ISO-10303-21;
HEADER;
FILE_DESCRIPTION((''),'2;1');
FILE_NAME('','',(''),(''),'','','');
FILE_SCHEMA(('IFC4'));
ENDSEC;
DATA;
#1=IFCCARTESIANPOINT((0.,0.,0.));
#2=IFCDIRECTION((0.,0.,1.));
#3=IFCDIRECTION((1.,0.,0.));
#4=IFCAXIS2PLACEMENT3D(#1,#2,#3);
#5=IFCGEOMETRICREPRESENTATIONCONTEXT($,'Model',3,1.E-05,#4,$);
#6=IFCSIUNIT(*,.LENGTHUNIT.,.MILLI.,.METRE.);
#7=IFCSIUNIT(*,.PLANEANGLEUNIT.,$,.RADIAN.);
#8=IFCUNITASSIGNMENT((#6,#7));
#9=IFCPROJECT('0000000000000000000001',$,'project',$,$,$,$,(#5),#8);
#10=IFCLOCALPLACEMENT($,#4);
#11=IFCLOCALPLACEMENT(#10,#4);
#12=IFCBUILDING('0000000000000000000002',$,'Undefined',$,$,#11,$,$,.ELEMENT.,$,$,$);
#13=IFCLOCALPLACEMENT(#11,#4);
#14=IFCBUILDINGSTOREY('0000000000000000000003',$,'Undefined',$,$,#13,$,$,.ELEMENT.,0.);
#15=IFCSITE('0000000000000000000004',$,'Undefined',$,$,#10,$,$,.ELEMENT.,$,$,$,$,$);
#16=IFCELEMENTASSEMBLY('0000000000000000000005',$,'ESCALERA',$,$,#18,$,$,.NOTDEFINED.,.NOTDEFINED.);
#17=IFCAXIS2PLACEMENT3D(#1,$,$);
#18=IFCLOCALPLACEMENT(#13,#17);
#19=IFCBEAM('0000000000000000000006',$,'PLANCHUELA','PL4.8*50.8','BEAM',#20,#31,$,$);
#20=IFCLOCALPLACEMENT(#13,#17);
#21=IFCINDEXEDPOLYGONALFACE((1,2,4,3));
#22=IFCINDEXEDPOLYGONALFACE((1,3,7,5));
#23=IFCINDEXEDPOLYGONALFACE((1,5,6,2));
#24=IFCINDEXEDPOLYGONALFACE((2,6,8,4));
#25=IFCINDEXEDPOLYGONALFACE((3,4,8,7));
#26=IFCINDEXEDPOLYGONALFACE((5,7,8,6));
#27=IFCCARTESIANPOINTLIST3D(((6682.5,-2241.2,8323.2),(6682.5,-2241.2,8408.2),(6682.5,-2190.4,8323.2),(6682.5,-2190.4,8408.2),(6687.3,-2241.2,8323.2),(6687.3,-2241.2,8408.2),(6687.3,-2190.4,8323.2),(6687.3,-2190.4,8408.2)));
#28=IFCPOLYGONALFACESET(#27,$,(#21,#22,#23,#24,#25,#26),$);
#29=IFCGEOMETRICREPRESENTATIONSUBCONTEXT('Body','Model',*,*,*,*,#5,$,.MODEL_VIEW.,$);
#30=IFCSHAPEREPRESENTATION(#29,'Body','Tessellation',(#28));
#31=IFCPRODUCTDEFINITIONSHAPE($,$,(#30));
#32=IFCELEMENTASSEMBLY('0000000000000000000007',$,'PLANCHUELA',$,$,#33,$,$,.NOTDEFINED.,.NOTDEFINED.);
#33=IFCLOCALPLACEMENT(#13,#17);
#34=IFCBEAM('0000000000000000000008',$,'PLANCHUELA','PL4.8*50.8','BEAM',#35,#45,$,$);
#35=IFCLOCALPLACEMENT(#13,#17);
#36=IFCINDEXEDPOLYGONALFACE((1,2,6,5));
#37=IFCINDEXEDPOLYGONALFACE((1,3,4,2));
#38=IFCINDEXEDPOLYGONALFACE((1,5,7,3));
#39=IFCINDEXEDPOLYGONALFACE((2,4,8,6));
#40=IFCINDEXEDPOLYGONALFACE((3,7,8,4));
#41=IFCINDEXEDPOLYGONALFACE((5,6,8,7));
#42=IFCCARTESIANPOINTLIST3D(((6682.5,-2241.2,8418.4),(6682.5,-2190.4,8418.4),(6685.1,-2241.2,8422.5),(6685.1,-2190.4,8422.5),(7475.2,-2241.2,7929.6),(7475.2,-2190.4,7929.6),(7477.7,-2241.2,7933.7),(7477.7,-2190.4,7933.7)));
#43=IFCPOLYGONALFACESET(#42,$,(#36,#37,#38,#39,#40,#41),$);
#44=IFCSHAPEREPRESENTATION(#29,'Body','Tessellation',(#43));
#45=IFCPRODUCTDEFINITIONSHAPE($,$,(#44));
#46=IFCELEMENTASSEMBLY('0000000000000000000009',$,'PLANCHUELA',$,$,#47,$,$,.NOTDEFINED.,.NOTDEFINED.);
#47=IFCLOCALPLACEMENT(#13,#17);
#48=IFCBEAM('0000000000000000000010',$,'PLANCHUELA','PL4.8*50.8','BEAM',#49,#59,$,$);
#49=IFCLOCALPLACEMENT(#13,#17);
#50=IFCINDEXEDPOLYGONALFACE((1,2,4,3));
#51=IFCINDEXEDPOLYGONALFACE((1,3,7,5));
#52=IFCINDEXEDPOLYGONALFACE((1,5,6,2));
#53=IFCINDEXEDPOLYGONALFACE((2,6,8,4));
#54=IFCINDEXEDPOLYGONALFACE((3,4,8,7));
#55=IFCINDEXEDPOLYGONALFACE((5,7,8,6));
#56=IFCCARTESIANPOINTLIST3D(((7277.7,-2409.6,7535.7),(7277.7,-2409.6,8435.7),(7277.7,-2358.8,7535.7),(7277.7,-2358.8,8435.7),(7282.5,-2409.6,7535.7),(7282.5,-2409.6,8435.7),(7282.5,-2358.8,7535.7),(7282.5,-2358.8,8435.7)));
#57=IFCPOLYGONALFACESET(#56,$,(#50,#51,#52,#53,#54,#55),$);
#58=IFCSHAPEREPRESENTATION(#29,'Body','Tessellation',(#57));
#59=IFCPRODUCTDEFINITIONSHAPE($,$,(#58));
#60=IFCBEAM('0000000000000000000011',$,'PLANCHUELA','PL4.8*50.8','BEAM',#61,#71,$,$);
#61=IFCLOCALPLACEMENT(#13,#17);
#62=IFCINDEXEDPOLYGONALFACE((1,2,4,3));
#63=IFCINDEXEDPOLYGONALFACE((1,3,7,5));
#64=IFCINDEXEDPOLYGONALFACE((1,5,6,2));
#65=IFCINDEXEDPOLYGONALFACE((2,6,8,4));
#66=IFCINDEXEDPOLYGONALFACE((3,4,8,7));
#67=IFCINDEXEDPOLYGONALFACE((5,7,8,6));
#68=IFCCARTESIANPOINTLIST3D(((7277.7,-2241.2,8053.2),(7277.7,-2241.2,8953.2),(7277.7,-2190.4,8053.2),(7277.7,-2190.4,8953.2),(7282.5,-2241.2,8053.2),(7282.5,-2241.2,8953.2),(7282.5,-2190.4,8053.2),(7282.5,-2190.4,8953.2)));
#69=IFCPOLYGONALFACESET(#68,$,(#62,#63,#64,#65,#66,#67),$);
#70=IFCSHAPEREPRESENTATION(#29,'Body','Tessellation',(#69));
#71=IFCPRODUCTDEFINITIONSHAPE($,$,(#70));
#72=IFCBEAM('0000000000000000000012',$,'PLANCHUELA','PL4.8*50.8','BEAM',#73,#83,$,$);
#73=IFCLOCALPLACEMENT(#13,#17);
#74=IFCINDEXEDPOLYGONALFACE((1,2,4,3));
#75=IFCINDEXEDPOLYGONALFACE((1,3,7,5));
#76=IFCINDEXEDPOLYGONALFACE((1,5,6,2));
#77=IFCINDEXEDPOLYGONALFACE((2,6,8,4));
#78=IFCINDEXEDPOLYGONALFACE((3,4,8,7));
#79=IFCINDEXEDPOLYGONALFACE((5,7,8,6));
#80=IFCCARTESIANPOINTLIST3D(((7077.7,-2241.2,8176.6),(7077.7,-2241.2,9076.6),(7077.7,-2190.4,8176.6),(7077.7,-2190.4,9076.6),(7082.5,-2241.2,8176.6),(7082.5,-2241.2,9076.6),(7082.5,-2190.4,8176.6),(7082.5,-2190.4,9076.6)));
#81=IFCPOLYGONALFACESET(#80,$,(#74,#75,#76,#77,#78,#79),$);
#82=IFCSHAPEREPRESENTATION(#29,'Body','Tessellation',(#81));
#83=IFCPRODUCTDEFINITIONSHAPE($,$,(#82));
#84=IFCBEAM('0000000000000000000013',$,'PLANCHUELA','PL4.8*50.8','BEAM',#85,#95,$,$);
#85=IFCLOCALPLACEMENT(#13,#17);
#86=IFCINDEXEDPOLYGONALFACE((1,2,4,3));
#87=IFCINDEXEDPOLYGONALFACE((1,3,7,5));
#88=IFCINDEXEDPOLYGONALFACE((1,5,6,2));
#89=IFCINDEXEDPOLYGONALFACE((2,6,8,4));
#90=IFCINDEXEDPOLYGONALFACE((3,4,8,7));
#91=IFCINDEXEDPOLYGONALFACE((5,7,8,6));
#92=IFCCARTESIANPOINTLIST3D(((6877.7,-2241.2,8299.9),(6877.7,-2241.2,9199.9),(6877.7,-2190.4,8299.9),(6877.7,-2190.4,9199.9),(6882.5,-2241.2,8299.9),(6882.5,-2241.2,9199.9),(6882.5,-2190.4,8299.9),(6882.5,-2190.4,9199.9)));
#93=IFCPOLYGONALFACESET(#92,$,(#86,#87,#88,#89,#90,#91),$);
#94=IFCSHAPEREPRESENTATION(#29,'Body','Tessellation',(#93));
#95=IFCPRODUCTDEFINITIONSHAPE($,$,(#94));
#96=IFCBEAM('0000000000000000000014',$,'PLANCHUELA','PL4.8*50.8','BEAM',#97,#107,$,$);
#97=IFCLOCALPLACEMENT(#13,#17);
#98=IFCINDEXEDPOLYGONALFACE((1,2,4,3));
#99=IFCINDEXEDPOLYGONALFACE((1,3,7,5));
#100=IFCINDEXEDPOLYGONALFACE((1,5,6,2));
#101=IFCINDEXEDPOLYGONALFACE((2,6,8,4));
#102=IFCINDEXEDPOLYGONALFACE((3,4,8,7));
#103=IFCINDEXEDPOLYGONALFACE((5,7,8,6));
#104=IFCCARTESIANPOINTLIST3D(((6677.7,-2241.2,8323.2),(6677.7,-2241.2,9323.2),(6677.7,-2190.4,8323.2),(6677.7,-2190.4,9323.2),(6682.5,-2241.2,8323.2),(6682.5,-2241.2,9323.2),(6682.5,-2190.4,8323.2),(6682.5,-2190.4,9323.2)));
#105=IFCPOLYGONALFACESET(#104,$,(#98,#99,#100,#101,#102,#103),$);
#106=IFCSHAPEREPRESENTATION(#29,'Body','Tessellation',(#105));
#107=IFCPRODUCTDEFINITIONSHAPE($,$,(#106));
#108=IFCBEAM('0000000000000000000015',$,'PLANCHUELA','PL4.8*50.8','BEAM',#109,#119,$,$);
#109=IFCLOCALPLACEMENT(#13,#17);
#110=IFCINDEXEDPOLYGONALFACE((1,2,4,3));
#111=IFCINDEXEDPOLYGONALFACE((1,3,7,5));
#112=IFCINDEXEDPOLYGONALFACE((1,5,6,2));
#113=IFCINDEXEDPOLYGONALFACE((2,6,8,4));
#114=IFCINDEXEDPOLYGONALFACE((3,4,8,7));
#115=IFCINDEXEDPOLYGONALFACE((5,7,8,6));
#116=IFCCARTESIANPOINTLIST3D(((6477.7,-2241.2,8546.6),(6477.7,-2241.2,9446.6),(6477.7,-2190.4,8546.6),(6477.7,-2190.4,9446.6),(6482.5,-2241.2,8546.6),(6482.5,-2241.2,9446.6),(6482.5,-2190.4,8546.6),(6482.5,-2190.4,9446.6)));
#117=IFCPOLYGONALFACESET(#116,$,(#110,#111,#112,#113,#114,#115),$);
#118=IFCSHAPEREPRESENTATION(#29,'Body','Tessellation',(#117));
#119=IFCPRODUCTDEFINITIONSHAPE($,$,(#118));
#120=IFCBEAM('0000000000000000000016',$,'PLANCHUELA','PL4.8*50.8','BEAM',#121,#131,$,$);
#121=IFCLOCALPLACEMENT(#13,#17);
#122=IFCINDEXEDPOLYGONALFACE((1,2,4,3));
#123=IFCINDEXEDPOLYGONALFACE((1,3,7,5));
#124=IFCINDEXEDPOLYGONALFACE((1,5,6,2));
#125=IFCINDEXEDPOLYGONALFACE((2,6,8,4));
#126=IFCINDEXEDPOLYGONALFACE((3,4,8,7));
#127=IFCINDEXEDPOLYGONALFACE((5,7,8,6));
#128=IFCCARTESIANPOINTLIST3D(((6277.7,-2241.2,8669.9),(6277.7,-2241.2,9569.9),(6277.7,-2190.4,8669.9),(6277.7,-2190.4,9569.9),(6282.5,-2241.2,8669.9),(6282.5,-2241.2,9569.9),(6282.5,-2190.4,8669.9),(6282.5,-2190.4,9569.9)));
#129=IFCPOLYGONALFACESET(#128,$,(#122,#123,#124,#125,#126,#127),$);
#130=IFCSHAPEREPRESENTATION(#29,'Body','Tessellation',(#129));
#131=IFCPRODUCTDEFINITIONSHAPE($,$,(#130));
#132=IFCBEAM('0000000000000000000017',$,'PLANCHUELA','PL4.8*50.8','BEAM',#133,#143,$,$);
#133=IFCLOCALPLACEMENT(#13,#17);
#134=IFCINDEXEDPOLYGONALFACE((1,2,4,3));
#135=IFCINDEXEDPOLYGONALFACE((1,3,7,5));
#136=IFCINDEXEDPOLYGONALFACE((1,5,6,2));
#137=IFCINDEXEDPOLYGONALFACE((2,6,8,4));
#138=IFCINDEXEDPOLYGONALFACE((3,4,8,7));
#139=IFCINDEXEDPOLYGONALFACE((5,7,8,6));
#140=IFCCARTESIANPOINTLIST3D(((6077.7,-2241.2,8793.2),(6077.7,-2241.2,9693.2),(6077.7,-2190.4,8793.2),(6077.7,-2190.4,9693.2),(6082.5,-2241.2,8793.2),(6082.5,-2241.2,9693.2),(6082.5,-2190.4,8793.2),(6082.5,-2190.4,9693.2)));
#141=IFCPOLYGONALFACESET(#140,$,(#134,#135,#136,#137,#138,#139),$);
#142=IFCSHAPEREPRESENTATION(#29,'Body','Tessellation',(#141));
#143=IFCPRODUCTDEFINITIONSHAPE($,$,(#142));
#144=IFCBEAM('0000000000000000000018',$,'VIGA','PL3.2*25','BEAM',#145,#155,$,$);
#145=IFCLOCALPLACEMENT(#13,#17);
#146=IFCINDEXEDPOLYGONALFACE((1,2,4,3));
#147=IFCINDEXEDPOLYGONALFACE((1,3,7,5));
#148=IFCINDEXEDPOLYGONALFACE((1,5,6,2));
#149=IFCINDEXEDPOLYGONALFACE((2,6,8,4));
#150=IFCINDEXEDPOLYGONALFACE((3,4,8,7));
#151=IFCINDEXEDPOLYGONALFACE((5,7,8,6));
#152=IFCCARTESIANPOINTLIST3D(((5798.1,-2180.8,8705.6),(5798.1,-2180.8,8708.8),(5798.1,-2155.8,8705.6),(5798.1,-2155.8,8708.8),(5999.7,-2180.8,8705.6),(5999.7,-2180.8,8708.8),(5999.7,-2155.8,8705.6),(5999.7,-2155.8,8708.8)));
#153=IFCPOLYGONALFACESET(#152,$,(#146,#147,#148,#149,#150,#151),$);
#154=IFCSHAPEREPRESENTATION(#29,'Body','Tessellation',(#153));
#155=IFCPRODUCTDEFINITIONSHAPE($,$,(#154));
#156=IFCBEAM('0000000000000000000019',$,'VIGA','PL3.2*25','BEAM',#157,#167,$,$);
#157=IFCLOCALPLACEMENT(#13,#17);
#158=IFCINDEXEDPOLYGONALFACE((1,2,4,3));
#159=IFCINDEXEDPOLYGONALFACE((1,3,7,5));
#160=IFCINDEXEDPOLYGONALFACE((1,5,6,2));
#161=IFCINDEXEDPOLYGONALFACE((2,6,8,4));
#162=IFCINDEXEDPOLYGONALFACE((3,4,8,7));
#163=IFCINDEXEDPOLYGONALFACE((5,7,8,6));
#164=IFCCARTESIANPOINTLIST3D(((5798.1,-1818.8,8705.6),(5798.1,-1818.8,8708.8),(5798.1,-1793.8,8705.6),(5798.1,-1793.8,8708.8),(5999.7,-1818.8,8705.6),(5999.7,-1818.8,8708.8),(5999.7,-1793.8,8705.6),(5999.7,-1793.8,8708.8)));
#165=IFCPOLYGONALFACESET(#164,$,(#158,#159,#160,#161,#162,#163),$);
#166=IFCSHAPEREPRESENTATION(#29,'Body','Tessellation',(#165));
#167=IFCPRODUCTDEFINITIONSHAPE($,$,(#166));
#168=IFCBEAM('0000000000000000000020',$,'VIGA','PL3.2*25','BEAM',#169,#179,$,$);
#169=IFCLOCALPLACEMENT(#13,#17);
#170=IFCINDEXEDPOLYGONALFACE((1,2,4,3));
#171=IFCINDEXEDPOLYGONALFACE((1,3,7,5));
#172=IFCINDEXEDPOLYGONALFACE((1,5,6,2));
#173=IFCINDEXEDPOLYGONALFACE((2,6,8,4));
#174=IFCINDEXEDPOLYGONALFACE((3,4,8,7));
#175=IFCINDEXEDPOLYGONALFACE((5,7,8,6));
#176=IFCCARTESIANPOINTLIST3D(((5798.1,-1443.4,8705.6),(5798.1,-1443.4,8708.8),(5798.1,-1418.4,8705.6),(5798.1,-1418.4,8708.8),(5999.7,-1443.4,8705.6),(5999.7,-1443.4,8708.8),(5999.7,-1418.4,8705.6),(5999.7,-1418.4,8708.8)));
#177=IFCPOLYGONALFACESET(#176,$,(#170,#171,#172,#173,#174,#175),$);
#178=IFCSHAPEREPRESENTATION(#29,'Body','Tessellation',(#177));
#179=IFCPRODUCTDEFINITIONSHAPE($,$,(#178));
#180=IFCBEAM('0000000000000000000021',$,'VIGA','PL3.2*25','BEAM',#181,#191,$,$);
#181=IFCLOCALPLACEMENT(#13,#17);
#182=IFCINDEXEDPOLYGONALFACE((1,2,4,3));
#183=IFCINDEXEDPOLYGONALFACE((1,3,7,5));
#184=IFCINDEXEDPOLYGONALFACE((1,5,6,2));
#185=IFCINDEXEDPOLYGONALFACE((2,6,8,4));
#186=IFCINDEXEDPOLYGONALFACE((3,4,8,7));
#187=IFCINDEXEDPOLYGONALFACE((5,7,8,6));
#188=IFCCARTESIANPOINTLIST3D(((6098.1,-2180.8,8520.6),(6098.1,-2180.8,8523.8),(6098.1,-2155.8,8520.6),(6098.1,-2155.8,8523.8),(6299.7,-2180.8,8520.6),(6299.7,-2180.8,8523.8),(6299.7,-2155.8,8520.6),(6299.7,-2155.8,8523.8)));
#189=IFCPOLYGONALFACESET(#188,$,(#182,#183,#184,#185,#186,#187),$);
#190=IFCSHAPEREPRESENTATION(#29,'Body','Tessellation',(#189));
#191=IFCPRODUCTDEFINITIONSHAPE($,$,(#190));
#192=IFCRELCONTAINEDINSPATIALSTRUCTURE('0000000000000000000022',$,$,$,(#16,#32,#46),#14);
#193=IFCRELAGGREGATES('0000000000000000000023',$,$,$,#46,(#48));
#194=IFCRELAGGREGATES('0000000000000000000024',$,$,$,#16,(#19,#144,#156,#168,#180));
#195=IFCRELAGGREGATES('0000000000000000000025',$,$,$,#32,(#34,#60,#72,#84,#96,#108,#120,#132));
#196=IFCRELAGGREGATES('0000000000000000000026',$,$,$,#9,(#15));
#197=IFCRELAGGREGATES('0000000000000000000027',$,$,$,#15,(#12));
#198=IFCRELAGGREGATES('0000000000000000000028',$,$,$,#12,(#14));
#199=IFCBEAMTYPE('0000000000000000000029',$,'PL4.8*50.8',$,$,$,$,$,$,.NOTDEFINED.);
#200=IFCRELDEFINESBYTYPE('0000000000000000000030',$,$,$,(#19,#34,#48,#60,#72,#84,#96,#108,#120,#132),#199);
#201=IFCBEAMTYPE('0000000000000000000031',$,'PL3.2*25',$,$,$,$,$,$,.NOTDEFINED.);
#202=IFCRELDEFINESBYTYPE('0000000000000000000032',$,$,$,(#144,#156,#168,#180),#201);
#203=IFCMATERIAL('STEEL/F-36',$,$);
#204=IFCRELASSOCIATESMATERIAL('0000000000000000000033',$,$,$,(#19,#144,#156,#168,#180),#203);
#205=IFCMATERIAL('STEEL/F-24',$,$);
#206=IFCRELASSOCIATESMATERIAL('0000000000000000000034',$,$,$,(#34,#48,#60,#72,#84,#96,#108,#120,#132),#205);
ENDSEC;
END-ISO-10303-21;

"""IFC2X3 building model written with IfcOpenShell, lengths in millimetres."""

from ifc_helpers import new_model, si_unit, frame, origin_with_axes, origin_2d_with_axis, place, context, subcontext, project, spatial, rectangle, extrude, material, type_object, element, aggregate, save


model = new_model("IFC2X3")

# Units and contexts
model_context = context("Model", 3, precision=1e-05, world=origin_with_axes())
body_context = subcontext(model_context, "Body", "Model", "MODEL_VIEW")
ifc_project = project(units=[si_unit("LENGTHUNIT", "METRE", prefix="MILLI"), si_unit("PLANEANGLEUNIT", "RADIAN")], contexts=[model_context])

# Site, building, storey
site_placement = place(None, origin_with_axes())
site = spatial("IfcSite", under=ifc_project, at=site_placement, Name="Undefined", CompositionType="ELEMENT")
building_placement = place(site_placement, origin_with_axes())
building = spatial("IfcBuilding", under=site, at=building_placement, Name="Undefined", CompositionType="ELEMENT")
storey_placement = place(building_placement, origin_with_axes())
storey = spatial("IfcBuildingStorey", under=building, at=storey_placement, Name="Undefined", CompositionType="ELEMENT", Elevation=0.0)

# Element assemblies, beams
assembly_1_placement = place(storey_placement, origin_with_axes())
assembly_1 = element("IfcElementAssembly", 1, at=assembly_1_placement, inside=storey, Name="ESCALERA", AssemblyPlace="NOTDEFINED", PredefinedType="NOTDEFINED")
ifc_material_1 = material(Name="STEEL/F-36")
beam_type_1 = type_object("IfcBeamType", Name="PL4.8*50.8", PredefinedType="NOTDEFINED")
beam_1_placement = place(assembly_1_placement, frame((6684.9, -2215.8, 8408.2), z_axis=(0.0, -1.0, 0.0), x_axis=(0.0, 0.0, -1.0)))
beam_1 = element("IfcBeam", 2, at=beam_1_placement, type_object=beam_type_1, material=ifc_material_1, Name="PLANCHUELA", Description="PL4.8*50.8", ObjectType="BEAM", context=body_context, shape_type="SweptSolid", body=[
    extrude(rectangle(XDim=4.8, YDim=50.8, at=origin_2d_with_axis()), frame((85.0, 0.0, 0.0), z_axis=(-1.0, 0.0, 0.0), x_axis=(0.0, -1.0, 0.0)), (0.0, 0.0, 1.0), 85.0),
])
assembly_2_placement = place(storey_placement, origin_with_axes())
assembly_2 = element("IfcElementAssembly", 3, at=assembly_2_placement, inside=storey, Name="PLANCHUELA", AssemblyPlace="NOTDEFINED", PredefinedType="NOTDEFINED")
ifc_material_2 = material(Name="STEEL/F-24")
beam_2_placement = place(assembly_2_placement, frame((6683.8, -2215.8, 8420.5), z_axis=(0.0, -1.0, 0.0), x_axis=(0.851171, 0.0, -0.524889)))
beam_2 = element("IfcBeam", 4, at=beam_2_placement, type_object=beam_type_1, material=ifc_material_2, Name="PLANCHUELA", Description="PL4.8*50.8", ObjectType="BEAM", context=body_context, shape_type="SweptSolid", body=[
    extrude(rectangle(XDim=4.8, YDim=50.8, at=origin_2d_with_axis()), frame((931.3, 0.0, 0.0), z_axis=(-1.0, 0.0, 0.0), x_axis=(0.0, -1.0, 0.0)), (0.0, 0.0, 1.0), 931.3),
])

# Element assembly, beam
assembly_3_placement = place(storey_placement, origin_with_axes())
assembly_3 = element("IfcElementAssembly", 5, at=assembly_3_placement, inside=storey, Name="PLANCHUELA", AssemblyPlace="NOTDEFINED", PredefinedType="NOTDEFINED")
beam_3_placement = place(assembly_3_placement, frame((7280.1, -2384.2, 8435.7), z_axis=(0.0, -1.0, 0.0), x_axis=(0.0, 0.0, -1.0)))
beam_3 = element("IfcBeam", 6, at=beam_3_placement, type_object=beam_type_1, material=ifc_material_2, Name="PLANCHUELA", Description="PL4.8*50.8", ObjectType="BEAM", context=body_context, shape_type="SweptSolid", body=[
    extrude(rectangle(XDim=4.8, YDim=50.8, at=origin_2d_with_axis()), frame((900.0, 0.0, 0.0), z_axis=(-1.0, 0.0, 0.0), x_axis=(0.0, -1.0, 0.0)), (0.0, 0.0, 1.0), 900.0),
])
aggregate(assembly_3, [beam_3])

# Beams
beam_4_placement = place(assembly_2_placement, frame((7280.1, -2215.8, 8953.2), z_axis=(0.0, -1.0, 0.0), x_axis=(0.0, 0.0, -1.0)))
beam_4 = element("IfcBeam", 7, at=beam_4_placement, type_object=beam_type_1, material=ifc_material_2, Name="PLANCHUELA", Description="PL4.8*50.8", ObjectType="BEAM", context=body_context, shape_type="SweptSolid", body=[
    extrude(rectangle(XDim=4.8, YDim=50.8, at=origin_2d_with_axis()), frame((900.0, 0.0, 0.0), z_axis=(-1.0, 0.0, 0.0), x_axis=(0.0, -1.0, 0.0)), (0.0, 0.0, 1.0), 900.0),
])
beam_5_placement = place(assembly_2_placement, frame((7080.1, -2215.8, 9076.6), z_axis=(0.0, -1.0, 0.0), x_axis=(0.0, 0.0, -1.0)))
beam_5 = element("IfcBeam", 8, at=beam_5_placement, type_object=beam_type_1, material=ifc_material_2, Name="PLANCHUELA", Description="PL4.8*50.8", ObjectType="BEAM", context=body_context, shape_type="SweptSolid", body=[
    extrude(rectangle(XDim=4.8, YDim=50.8, at=origin_2d_with_axis()), frame((900.0, 0.0, 0.0), z_axis=(-1.0, 0.0, 0.0), x_axis=(0.0, -1.0, 0.0)), (0.0, 0.0, 1.0), 900.0),
])
beam_6_placement = place(assembly_2_placement, frame((6880.1, -2215.8, 9199.9), z_axis=(0.0, -1.0, 0.0), x_axis=(0.0, 0.0, -1.0)))
beam_6 = element("IfcBeam", 9, at=beam_6_placement, type_object=beam_type_1, material=ifc_material_2, Name="PLANCHUELA", Description="PL4.8*50.8", ObjectType="BEAM", context=body_context, shape_type="SweptSolid", body=[
    extrude(rectangle(XDim=4.8, YDim=50.8, at=origin_2d_with_axis()), frame((900.0, 0.0, 0.0), z_axis=(-1.0, 0.0, 0.0), x_axis=(0.0, -1.0, 0.0)), (0.0, 0.0, 1.0), 900.0),
])
beam_7_placement = place(assembly_2_placement, frame((6680.1, -2215.8, 9323.2), z_axis=(0.0, -1.0, 0.0), x_axis=(0.0, 0.0, -1.0)))
beam_7 = element("IfcBeam", 10, at=beam_7_placement, type_object=beam_type_1, material=ifc_material_2, Name="PLANCHUELA", Description="PL4.8*50.8", ObjectType="BEAM", context=body_context, shape_type="SweptSolid", body=[
    extrude(rectangle(XDim=4.8, YDim=50.8, at=origin_2d_with_axis()), frame((1000.0, 0.0, 0.0), z_axis=(-1.0, 0.0, 0.0), x_axis=(0.0, -1.0, 0.0)), (0.0, 0.0, 1.0), 1000.0),
])
beam_8_placement = place(assembly_2_placement, frame((6480.1, -2215.8, 9446.6), z_axis=(0.0, -1.0, 0.0), x_axis=(0.0, 0.0, -1.0)))
beam_8 = element("IfcBeam", 11, at=beam_8_placement, type_object=beam_type_1, material=ifc_material_2, Name="PLANCHUELA", Description="PL4.8*50.8", ObjectType="BEAM", context=body_context, shape_type="SweptSolid", body=[
    extrude(rectangle(XDim=4.8, YDim=50.8, at=origin_2d_with_axis()), frame((900.0, 0.0, 0.0), z_axis=(-1.0, 0.0, 0.0), x_axis=(0.0, -1.0, 0.0)), (0.0, 0.0, 1.0), 900.0),
])
beam_9_placement = place(assembly_2_placement, frame((6280.1, -2215.8, 9569.9), z_axis=(0.0, -1.0, 0.0), x_axis=(0.0, 0.0, -1.0)))
beam_9 = element("IfcBeam", 12, at=beam_9_placement, type_object=beam_type_1, material=ifc_material_2, Name="PLANCHUELA", Description="PL4.8*50.8", ObjectType="BEAM", context=body_context, shape_type="SweptSolid", body=[
    extrude(rectangle(XDim=4.8, YDim=50.8, at=origin_2d_with_axis()), frame((900.0, 0.0, 0.0), z_axis=(-1.0, 0.0, 0.0), x_axis=(0.0, -1.0, 0.0)), (0.0, 0.0, 1.0), 900.0),
])
beam_10_placement = place(assembly_2_placement, frame((6080.1, -2215.8, 9693.2), z_axis=(0.0, -1.0, 0.0), x_axis=(0.0, 0.0, -1.0)))
beam_10 = element("IfcBeam", 13, at=beam_10_placement, type_object=beam_type_1, material=ifc_material_2, Name="PLANCHUELA", Description="PL4.8*50.8", ObjectType="BEAM", context=body_context, shape_type="SweptSolid", body=[
    extrude(rectangle(XDim=4.8, YDim=50.8, at=origin_2d_with_axis()), frame((900.0, 0.0, 0.0), z_axis=(-1.0, 0.0, 0.0), x_axis=(0.0, -1.0, 0.0)), (0.0, 0.0, 1.0), 900.0),
])
beam_type_2 = type_object("IfcBeamType", Name="PL3.2*25", PredefinedType="NOTDEFINED")
beam_11_placement = place(assembly_1_placement, frame((5999.7, -2168.3, 8707.2), z_axis=(0.0, 1.0, 0.0), x_axis=(-1.0, 0.0, 0.000012)))
beam_11 = element("IfcBeam", 14, at=beam_11_placement, type_object=beam_type_2, material=ifc_material_1, Name="VIGA", Description="PL3.2*25", ObjectType="BEAM", context=body_context, shape_type="SweptSolid", body=[
    extrude(rectangle(XDim=3.2, YDim=25.0, at=origin_2d_with_axis()), frame((201.6, 0.0, 0.0), z_axis=(-1.0, 0.0, 0.0), x_axis=(0.0, -1.0, 0.0)), (0.0, 0.0, 1.0), 201.6),
])
beam_12_placement = place(assembly_1_placement, frame((5999.7, -1806.3, 8707.2), z_axis=(0.0, 1.0, 0.0), x_axis=(-1.0, 0.0, 0.000012)))
beam_12 = element("IfcBeam", 15, at=beam_12_placement, type_object=beam_type_2, material=ifc_material_1, Name="VIGA", Description="PL3.2*25", ObjectType="BEAM", context=body_context, shape_type="SweptSolid", body=[
    extrude(rectangle(XDim=3.2, YDim=25.0, at=origin_2d_with_axis()), frame((201.6, 0.0, 0.0), z_axis=(-1.0, 0.0, 0.0), x_axis=(0.0, -1.0, 0.0)), (0.0, 0.0, 1.0), 201.6),
])
beam_13_placement = place(assembly_1_placement, frame((5999.7, -1430.9, 8707.2), z_axis=(0.0, 1.0, 0.0), x_axis=(-1.0, 0.0, 0.000012)))
beam_13 = element("IfcBeam", 16, at=beam_13_placement, type_object=beam_type_2, material=ifc_material_1, Name="VIGA", Description="PL3.2*25", ObjectType="BEAM", context=body_context, shape_type="SweptSolid", body=[
    extrude(rectangle(XDim=3.2, YDim=25.0, at=origin_2d_with_axis()), frame((201.6, 0.0, 0.0), z_axis=(-1.0, 0.0, 0.0), x_axis=(0.0, -1.0, 0.0)), (0.0, 0.0, 1.0), 201.6),
])
beam_14_placement = place(assembly_1_placement, frame((6299.7, -2168.3, 8522.2), z_axis=(0.0, 1.0, 0.0), x_axis=(-1.0, 0.0, 0.000012)))
beam_14 = element("IfcBeam", 17, at=beam_14_placement, type_object=beam_type_2, material=ifc_material_1, Name="VIGA", Description="PL3.2*25", ObjectType="BEAM", context=body_context, shape_type="SweptSolid", body=[
    extrude(rectangle(XDim=3.2, YDim=25.0, at=origin_2d_with_axis()), frame((201.6, 0.0, 0.0), z_axis=(-1.0, 0.0, 0.0), x_axis=(0.0, -1.0, 0.0)), (0.0, 0.0, 1.0), 201.6),
])

aggregate(assembly_1, [beam_1, beam_11, beam_12, beam_13, beam_14])

aggregate(assembly_2, [beam_2, beam_4, beam_5, beam_6, beam_7, beam_8, beam_9, beam_10])

save(model, "model.ifc")
